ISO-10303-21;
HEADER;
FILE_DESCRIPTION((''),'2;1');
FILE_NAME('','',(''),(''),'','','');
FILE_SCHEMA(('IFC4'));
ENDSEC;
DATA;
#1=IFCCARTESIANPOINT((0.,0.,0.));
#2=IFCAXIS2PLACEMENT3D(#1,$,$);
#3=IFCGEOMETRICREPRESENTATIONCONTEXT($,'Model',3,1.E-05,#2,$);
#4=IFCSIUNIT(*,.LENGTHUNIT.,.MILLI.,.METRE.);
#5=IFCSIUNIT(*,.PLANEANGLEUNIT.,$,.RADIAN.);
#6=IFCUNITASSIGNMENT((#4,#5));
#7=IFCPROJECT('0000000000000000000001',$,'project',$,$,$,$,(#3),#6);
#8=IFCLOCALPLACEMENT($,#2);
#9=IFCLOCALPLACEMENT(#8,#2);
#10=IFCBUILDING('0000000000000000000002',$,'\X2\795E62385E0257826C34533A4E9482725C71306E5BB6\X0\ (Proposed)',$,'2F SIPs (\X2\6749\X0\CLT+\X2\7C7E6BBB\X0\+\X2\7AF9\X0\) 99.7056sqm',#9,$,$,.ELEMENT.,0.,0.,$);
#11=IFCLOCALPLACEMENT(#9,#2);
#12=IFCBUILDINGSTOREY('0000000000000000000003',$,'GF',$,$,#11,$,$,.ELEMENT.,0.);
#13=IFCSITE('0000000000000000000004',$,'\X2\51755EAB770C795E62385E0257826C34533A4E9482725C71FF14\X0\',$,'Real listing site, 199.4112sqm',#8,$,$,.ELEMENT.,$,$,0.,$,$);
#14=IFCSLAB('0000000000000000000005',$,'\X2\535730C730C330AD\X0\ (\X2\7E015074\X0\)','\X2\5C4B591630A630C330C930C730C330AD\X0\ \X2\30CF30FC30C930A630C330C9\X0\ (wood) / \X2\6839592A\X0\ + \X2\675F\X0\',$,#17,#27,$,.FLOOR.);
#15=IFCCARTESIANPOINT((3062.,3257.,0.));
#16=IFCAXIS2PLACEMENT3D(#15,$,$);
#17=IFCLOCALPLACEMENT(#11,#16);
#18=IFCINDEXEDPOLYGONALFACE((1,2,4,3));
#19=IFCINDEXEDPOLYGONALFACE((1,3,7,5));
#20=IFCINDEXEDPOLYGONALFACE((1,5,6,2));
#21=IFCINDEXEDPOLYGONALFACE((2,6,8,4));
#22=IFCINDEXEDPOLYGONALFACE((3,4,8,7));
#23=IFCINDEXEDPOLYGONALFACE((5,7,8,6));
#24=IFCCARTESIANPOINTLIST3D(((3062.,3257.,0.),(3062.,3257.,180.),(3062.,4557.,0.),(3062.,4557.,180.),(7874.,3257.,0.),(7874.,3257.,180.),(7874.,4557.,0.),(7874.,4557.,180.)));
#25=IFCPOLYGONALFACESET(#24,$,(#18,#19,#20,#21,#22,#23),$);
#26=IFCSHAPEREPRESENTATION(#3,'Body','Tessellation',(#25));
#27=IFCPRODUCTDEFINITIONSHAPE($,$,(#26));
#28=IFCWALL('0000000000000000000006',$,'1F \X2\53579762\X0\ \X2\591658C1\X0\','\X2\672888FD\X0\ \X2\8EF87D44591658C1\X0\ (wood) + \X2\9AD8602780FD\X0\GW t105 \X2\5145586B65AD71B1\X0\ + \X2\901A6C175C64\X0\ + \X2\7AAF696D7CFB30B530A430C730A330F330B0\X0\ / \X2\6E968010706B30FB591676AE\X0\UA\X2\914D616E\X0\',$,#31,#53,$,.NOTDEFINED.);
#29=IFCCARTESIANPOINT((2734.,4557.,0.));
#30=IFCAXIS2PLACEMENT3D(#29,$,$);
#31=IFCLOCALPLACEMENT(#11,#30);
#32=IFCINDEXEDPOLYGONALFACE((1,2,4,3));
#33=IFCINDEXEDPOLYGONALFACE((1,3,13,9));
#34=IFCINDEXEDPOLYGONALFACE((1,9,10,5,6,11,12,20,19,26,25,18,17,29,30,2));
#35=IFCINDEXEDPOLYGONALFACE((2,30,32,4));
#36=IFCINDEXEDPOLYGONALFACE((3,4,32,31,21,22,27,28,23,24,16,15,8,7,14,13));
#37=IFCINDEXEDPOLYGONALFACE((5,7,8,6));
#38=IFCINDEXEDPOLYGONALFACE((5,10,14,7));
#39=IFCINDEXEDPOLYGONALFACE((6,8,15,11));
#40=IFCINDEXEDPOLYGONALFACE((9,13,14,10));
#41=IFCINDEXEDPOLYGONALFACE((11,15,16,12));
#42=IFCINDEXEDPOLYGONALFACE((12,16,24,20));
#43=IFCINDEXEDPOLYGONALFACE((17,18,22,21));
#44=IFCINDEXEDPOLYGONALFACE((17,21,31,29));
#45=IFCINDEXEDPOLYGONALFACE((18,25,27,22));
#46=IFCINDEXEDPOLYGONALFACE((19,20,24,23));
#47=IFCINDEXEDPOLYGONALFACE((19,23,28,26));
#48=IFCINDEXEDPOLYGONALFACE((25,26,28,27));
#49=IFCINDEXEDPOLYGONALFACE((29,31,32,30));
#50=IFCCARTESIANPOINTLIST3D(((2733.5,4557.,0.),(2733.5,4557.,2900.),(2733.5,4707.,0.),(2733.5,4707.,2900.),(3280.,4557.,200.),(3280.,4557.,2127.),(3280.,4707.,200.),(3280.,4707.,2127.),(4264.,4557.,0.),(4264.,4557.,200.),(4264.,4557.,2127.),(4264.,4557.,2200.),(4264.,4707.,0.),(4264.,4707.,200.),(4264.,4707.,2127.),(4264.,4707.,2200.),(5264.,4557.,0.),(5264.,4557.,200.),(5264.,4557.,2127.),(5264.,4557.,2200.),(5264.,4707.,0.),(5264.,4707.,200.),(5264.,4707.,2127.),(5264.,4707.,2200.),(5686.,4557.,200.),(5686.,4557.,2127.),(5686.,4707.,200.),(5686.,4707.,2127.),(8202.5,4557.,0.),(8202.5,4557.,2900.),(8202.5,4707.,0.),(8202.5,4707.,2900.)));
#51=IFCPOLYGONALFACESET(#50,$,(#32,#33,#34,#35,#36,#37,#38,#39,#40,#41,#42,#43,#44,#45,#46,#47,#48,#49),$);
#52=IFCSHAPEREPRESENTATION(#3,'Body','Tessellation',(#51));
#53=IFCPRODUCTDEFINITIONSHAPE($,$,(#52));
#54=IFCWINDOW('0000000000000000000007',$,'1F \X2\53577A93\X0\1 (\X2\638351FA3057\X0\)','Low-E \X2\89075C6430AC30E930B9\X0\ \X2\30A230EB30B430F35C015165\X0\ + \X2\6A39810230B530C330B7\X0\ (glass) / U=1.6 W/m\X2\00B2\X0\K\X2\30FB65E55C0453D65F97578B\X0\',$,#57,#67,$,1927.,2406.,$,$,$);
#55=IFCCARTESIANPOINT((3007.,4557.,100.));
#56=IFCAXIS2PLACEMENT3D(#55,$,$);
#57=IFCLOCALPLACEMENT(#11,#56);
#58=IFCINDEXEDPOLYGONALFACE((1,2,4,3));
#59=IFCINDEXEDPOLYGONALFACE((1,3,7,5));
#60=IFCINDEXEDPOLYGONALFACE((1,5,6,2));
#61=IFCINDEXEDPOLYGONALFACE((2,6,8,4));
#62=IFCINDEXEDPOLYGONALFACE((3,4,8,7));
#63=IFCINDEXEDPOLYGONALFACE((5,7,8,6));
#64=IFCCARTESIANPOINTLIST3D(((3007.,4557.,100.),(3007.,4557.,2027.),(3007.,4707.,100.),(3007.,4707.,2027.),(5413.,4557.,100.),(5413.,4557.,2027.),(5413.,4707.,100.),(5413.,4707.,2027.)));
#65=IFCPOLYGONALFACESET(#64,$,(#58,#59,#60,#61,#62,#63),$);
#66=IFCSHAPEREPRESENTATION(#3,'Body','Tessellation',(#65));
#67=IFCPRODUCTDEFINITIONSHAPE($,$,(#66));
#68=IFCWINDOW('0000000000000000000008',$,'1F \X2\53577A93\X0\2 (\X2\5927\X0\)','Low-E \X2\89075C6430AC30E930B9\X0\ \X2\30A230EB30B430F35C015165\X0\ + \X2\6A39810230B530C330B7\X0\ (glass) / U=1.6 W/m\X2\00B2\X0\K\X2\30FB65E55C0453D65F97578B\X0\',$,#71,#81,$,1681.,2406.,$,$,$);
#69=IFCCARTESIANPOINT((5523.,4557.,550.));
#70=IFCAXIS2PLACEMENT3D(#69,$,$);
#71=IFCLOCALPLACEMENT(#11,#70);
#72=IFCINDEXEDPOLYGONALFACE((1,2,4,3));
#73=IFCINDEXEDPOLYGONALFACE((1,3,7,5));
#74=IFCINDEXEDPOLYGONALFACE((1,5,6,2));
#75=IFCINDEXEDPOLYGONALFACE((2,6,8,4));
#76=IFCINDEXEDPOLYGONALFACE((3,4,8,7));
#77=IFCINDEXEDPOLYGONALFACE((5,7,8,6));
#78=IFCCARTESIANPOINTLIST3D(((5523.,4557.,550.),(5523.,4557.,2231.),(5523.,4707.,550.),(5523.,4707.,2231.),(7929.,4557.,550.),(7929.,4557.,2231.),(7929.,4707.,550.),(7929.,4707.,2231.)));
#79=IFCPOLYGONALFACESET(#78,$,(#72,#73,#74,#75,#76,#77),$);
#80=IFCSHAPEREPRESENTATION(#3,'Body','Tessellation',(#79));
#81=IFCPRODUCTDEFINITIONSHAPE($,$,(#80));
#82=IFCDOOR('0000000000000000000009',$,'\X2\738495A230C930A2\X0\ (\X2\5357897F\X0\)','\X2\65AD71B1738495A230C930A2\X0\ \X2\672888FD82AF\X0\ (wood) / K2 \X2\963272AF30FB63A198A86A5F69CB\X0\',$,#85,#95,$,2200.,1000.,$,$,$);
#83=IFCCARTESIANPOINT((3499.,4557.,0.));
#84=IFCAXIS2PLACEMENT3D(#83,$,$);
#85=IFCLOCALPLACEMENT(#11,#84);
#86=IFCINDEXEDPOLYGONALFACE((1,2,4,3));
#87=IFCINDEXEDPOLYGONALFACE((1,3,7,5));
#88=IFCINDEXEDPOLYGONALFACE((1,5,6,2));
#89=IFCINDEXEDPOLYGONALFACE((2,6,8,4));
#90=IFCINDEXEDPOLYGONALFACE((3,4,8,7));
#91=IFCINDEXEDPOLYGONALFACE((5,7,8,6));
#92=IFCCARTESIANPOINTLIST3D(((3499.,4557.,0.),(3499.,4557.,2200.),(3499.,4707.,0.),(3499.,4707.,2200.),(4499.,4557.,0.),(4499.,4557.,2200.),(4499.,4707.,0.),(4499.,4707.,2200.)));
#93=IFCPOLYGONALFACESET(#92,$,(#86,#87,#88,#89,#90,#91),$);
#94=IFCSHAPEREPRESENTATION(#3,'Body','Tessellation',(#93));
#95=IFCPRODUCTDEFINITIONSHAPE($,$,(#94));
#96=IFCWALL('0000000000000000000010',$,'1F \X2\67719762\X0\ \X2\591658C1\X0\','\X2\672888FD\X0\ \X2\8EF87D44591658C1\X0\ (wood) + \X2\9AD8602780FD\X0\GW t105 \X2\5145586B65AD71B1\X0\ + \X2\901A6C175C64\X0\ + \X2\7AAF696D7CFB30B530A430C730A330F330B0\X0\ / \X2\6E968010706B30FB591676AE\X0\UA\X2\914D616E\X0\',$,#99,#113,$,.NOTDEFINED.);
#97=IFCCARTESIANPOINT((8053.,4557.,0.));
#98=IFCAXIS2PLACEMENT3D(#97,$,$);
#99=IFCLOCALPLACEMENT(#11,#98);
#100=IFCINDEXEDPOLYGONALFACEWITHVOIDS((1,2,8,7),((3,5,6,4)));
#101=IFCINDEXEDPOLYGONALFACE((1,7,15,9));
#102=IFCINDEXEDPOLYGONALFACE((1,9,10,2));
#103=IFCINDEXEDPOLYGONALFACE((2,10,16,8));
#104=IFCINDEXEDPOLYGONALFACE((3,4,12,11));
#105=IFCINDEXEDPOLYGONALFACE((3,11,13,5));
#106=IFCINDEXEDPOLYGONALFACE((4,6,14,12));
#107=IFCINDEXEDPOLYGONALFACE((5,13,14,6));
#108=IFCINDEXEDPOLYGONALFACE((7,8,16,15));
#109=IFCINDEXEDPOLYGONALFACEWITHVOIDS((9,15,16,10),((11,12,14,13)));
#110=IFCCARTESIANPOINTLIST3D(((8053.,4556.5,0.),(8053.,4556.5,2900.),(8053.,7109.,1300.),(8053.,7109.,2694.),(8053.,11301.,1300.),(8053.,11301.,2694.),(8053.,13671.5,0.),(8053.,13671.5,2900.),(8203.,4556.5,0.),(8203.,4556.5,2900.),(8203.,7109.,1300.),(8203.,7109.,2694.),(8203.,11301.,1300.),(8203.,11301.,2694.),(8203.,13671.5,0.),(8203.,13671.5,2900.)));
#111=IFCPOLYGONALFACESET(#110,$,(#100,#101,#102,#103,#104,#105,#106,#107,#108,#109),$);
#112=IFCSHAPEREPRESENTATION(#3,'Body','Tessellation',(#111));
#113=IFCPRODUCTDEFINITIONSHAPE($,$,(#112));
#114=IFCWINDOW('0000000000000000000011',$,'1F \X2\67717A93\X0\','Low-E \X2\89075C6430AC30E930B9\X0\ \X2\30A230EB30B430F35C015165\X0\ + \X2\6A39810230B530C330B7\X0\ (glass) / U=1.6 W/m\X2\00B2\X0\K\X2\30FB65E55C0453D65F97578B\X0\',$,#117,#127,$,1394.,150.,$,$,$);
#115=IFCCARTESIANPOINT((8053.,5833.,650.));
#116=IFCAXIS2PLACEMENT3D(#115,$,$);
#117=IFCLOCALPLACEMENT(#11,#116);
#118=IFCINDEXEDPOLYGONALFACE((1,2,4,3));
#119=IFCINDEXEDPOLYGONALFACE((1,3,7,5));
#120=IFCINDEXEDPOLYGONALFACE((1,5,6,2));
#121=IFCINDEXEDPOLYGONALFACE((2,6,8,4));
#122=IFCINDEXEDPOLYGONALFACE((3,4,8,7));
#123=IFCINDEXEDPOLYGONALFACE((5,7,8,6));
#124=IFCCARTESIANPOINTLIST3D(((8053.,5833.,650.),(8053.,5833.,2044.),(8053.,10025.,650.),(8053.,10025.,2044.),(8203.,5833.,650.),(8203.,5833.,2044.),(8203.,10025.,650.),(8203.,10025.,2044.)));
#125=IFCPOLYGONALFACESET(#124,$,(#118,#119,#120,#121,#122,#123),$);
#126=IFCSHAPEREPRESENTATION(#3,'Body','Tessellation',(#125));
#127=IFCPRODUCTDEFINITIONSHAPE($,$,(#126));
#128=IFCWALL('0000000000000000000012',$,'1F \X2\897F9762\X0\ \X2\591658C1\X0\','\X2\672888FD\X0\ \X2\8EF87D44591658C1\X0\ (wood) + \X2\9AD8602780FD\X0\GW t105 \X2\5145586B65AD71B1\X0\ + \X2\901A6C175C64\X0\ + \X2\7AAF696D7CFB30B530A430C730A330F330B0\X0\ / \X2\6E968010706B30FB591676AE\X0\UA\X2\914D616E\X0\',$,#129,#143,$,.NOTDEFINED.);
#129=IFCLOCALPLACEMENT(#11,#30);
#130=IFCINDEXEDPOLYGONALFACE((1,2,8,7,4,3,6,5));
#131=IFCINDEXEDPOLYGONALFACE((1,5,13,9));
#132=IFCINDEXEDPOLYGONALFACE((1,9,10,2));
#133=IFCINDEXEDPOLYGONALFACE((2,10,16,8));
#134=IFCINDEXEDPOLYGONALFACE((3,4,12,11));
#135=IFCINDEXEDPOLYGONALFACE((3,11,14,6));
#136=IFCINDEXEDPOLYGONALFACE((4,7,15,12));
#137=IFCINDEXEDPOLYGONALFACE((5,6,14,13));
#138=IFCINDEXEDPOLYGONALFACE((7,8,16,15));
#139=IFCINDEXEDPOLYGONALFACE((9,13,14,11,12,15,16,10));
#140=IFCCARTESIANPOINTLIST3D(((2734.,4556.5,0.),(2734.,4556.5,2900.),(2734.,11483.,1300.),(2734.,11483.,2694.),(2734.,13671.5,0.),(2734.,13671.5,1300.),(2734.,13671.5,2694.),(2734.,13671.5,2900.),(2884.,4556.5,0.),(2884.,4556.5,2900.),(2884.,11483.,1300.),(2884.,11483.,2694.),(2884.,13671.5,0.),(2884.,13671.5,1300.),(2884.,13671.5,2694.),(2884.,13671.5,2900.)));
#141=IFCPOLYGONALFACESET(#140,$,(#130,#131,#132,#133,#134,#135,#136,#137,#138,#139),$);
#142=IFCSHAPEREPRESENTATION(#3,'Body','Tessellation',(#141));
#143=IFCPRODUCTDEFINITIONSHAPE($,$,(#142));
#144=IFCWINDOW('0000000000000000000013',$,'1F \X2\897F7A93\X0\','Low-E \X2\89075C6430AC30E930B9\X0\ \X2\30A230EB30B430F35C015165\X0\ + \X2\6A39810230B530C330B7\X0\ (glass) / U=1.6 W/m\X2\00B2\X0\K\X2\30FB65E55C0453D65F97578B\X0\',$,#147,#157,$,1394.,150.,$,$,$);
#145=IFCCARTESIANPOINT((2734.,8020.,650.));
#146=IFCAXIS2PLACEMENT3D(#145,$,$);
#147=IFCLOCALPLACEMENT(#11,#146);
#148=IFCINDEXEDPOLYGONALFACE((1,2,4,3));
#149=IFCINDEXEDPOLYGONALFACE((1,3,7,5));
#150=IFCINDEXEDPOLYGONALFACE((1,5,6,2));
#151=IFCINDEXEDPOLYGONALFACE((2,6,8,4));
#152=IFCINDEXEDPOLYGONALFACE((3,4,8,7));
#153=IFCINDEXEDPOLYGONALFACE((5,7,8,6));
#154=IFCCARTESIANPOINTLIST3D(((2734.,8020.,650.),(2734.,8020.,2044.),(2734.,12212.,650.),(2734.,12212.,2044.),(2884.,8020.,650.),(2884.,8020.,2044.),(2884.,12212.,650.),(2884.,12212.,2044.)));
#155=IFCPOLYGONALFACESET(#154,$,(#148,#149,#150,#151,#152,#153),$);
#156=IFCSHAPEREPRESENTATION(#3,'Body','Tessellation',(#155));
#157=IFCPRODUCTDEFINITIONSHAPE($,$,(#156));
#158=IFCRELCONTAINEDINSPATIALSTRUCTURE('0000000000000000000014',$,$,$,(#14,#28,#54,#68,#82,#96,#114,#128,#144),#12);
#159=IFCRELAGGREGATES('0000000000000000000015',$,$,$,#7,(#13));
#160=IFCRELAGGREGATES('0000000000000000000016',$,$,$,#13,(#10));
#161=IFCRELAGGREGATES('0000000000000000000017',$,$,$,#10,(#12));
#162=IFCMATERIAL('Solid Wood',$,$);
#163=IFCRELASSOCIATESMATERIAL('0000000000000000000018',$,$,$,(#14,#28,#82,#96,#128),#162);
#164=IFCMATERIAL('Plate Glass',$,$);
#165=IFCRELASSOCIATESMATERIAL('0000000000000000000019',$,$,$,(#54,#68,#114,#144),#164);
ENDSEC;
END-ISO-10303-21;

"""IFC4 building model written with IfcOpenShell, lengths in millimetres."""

from ifc_helpers import new_model, si_unit, frame, frame_2d, origin, place, context, project, spatial, rectangle, extrude, material, element, fill, save


model = new_model("IFC4")

# Units and contexts
model_context = context("Model", 3, precision=1e-05, world=origin())
ifc_project = project(units=[si_unit("LENGTHUNIT", "METRE", prefix="MILLI"), si_unit("PLANEANGLEUNIT", "RADIAN")], contexts=[model_context])

# Site, building, storey
site_placement = place(None, origin())
site = spatial("IfcSite", under=ifc_project, at=site_placement, Name="兵庫県神戸市垂水区五色山４", ObjectType="Real listing site, 199.4112sqm", CompositionType="ELEMENT", RefElevation=0.0)
building_placement = place(site_placement, origin())
building = spatial("IfcBuilding", under=site, at=building_placement, Name="神戸市垂水区五色山の家 (Proposed)", ObjectType="2F SIPs (杉CLT+籾殻+竹) 99.7056sqm", CompositionType="ELEMENT", ElevationOfRefHeight=0.0, ElevationOfTerrain=0.0)
storey_placement = place(building_placement, origin())
storey = spatial("IfcBuildingStorey", under=building, at=storey_placement, Name="GF", CompositionType="ELEMENT", Elevation=0.0)

# Slab
ifc_material_1 = material(Name="Solid Wood")
slab_1_placement = place(storey_placement, frame((3062.0, 3257.0, 0.0)))
element("IfcSlab", 1, at=slab_1_placement, inside=storey, material=ifc_material_1, Name="南デッキ (縁側)", Description="屋外ウッドデッキ ハードウッド (wood) / 根太 + 束", PredefinedType="FLOOR", context=model_context, shape_type="SweptSolid", body=[
    extrude(rectangle(XDim=4812.0, YDim=1300.0, at=frame_2d((2406.0, 650.0))), frame((3062.0, 3257.0, 0.0)), (0.0, 0.0, 1.0), 180.0),
])

# Wall, openings, windows, door
wall_1_placement = place(storey_placement, frame((2734.0, 4557.0, 0.0)))
wall_1 = element("IfcWall", 2, at=wall_1_placement, inside=storey, material=ifc_material_1, Name="1F 南面 外壁", Description="木製 軸組外壁 (wood) + 高性能GW t105 充填断熱 + 通気層 + 窯業系サイディング / 準耐火・外皮UA配慮", PredefinedType="NOTDEFINED", context=model_context, shape_type="SweptSolid", body=[
    extrude(rectangle(XDim=5469.0, YDim=150.0, at=frame_2d((2734.0, 75.0))), frame((2734.0, 4557.0, 0.0)), (0.0, 0.0, 1.0), 2900.0),
])
opening_1_placement = place(storey_placement, frame((3007.0, 4557.0, 100.0)))
opening_1 = element("IfcOpeningElement", 3, at=opening_1_placement, cuts=wall_1, PredefinedType="NOTDEFINED", context=model_context, shape_type="SweptSolid", body=[
    extrude(rectangle(XDim=2406.0, YDim=150.0, at=frame_2d((1203.0, 75.0))), frame((3007.0, 4557.0, 100.0)), (0.0, 0.0, 1.0), 1927.0),
])
opening_2_placement = place(storey_placement, frame((5523.0, 4557.0, 550.0)))
opening_2 = element("IfcOpeningElement", 4, at=opening_2_placement, cuts=wall_1, PredefinedType="NOTDEFINED", context=model_context, shape_type="SweptSolid", body=[
    extrude(rectangle(XDim=2406.0, YDim=150.0, at=frame_2d((1203.0, 75.0))), frame((5523.0, 4557.0, 550.0)), (0.0, 0.0, 1.0), 1681.0),
])
opening_3_placement = place(storey_placement, frame((3499.0, 4557.0, 0.0)))
opening_3 = element("IfcOpeningElement", 5, at=opening_3_placement, cuts=wall_1, PredefinedType="NOTDEFINED", context=model_context, shape_type="SweptSolid", body=[
    extrude(rectangle(XDim=1000.0, YDim=150.0, at=frame_2d((500.0, 75.0))), frame((3499.0, 4557.0, 0.0)), (0.0, 0.0, 1.0), 2200.0),
])
ifc_material_2 = material(Name="Plate Glass")
window_1_placement = place(storey_placement, frame((3007.0, 4557.0, 100.0)))
window_1 = element("IfcWindow", 6, at=window_1_placement, inside=storey, material=ifc_material_2, Name="1F 南窓1 (掃出し)", Description="Low-E 複層ガラス アルゴン封入 + 樹脂サッシ (glass) / U=1.6 W/m²K・日射取得型", OverallHeight=1927.0, OverallWidth=2406.0, context=model_context, shape_type="SweptSolid", body=[
    extrude(rectangle(XDim=2406.0, YDim=150.0, at=frame_2d((1203.0, 75.0))), frame((3007.0, 4557.0, 100.0)), (0.0, 0.0, 1.0), 1927.0),
])
fill(opening_1, window_1)
window_2_placement = place(storey_placement, frame((5523.0, 4557.0, 550.0)))
window_2 = element("IfcWindow", 7, at=window_2_placement, inside=storey, material=ifc_material_2, Name="1F 南窓2 (大)", Description="Low-E 複層ガラス アルゴン封入 + 樹脂サッシ (glass) / U=1.6 W/m²K・日射取得型", OverallHeight=1681.0, OverallWidth=2406.0, context=model_context, shape_type="SweptSolid", body=[
    extrude(rectangle(XDim=2406.0, YDim=150.0, at=frame_2d((1203.0, 75.0))), frame((5523.0, 4557.0, 550.0)), (0.0, 0.0, 1.0), 1681.0),
])
fill(opening_2, window_2)
door_placement = place(storey_placement, frame((3499.0, 4557.0, 0.0)))
door = element("IfcDoor", 8, at=door_placement, inside=storey, material=ifc_material_1, Name="玄関ドア (南西)", Description="断熱玄関ドア 木製芯 (wood) / K2 防犯・採風機構", OverallHeight=2200.0, OverallWidth=1000.0, context=model_context, shape_type="SweptSolid", body=[
    extrude(rectangle(XDim=1000.0, YDim=150.0, at=frame_2d((500.0, 75.0))), frame((3499.0, 4557.0, 0.0)), (0.0, 0.0, 1.0), 2200.0),
])
fill(opening_3, door)

# Walls, openings, windows
wall_2_placement = place(storey_placement, frame((8053.0, 4557.0, 0.0)))
wall_2 = element("IfcWall", 9, at=wall_2_placement, inside=storey, material=ifc_material_1, Name="1F 東面 外壁", Description="木製 軸組外壁 (wood) + 高性能GW t105 充填断熱 + 通気層 + 窯業系サイディング / 準耐火・外皮UA配慮", PredefinedType="NOTDEFINED", context=model_context, shape_type="SweptSolid", body=[
    extrude(rectangle(XDim=150.0, YDim=9115.0, at=frame_2d((75.0, 4557.0))), frame((8053.0, 4557.0, 0.0)), (0.0, 0.0, 1.0), 2900.0),
])
opening_4_placement = place(storey_placement, frame((8053.0, 5833.0, 650.0)))
opening_4 = element("IfcOpeningElement", 10, at=opening_4_placement, cuts=wall_2, PredefinedType="NOTDEFINED", context=model_context, shape_type="SweptSolid", body=[
    extrude(rectangle(XDim=150.0, YDim=4192.0, at=frame_2d((75.0, 2096.0))), frame((8053.0, 5833.0, 650.0)), (0.0, 0.0, 1.0), 1394.0),
])
window_3_placement = place(storey_placement, frame((8053.0, 5833.0, 650.0)))
window_3 = element("IfcWindow", 11, at=window_3_placement, inside=storey, material=ifc_material_2, Name="1F 東窓", Description="Low-E 複層ガラス アルゴン封入 + 樹脂サッシ (glass) / U=1.6 W/m²K・日射取得型", OverallHeight=1394.0, OverallWidth=150.0, context=model_context, shape_type="SweptSolid", body=[
    extrude(rectangle(XDim=150.0, YDim=4192.0, at=frame_2d((75.0, 2096.0))), frame((8053.0, 5833.0, 650.0)), (0.0, 0.0, 1.0), 1394.0),
])
fill(opening_4, window_3)
wall_3_placement = place(storey_placement, frame((2734.0, 4557.0, 0.0)))
wall_3 = element("IfcWall", 12, at=wall_3_placement, inside=storey, material=ifc_material_1, Name="1F 西面 外壁", Description="木製 軸組外壁 (wood) + 高性能GW t105 充填断熱 + 通気層 + 窯業系サイディング / 準耐火・外皮UA配慮", PredefinedType="NOTDEFINED", context=model_context, shape_type="SweptSolid", body=[
    extrude(rectangle(XDim=150.0, YDim=9115.0, at=frame_2d((75.0, 4557.0))), frame((2734.0, 4557.0, 0.0)), (0.0, 0.0, 1.0), 2900.0),
])
opening_5_placement = place(storey_placement, frame((2734.0, 8020.0, 650.0)))
opening_5 = element("IfcOpeningElement", 13, at=opening_5_placement, cuts=wall_3, PredefinedType="NOTDEFINED", context=model_context, shape_type="SweptSolid", body=[
    extrude(rectangle(XDim=150.0, YDim=4192.0, at=frame_2d((75.0, 2096.0))), frame((2734.0, 8020.0, 650.0)), (0.0, 0.0, 1.0), 1394.0),
])
window_4_placement = place(storey_placement, frame((2734.0, 8020.0, 650.0)))
window_4 = element("IfcWindow", 14, at=window_4_placement, inside=storey, material=ifc_material_2, Name="1F 西窓", Description="Low-E 複層ガラス アルゴン封入 + 樹脂サッシ (glass) / U=1.6 W/m²K・日射取得型", OverallHeight=1394.0, OverallWidth=150.0, context=model_context, shape_type="SweptSolid", body=[
    extrude(rectangle(XDim=150.0, YDim=4192.0, at=frame_2d((75.0, 2096.0))), frame((2734.0, 8020.0, 650.0)), (0.0, 0.0, 1.0), 1394.0),
])
fill(opening_5, window_4)

save(model, "model.ifc")
